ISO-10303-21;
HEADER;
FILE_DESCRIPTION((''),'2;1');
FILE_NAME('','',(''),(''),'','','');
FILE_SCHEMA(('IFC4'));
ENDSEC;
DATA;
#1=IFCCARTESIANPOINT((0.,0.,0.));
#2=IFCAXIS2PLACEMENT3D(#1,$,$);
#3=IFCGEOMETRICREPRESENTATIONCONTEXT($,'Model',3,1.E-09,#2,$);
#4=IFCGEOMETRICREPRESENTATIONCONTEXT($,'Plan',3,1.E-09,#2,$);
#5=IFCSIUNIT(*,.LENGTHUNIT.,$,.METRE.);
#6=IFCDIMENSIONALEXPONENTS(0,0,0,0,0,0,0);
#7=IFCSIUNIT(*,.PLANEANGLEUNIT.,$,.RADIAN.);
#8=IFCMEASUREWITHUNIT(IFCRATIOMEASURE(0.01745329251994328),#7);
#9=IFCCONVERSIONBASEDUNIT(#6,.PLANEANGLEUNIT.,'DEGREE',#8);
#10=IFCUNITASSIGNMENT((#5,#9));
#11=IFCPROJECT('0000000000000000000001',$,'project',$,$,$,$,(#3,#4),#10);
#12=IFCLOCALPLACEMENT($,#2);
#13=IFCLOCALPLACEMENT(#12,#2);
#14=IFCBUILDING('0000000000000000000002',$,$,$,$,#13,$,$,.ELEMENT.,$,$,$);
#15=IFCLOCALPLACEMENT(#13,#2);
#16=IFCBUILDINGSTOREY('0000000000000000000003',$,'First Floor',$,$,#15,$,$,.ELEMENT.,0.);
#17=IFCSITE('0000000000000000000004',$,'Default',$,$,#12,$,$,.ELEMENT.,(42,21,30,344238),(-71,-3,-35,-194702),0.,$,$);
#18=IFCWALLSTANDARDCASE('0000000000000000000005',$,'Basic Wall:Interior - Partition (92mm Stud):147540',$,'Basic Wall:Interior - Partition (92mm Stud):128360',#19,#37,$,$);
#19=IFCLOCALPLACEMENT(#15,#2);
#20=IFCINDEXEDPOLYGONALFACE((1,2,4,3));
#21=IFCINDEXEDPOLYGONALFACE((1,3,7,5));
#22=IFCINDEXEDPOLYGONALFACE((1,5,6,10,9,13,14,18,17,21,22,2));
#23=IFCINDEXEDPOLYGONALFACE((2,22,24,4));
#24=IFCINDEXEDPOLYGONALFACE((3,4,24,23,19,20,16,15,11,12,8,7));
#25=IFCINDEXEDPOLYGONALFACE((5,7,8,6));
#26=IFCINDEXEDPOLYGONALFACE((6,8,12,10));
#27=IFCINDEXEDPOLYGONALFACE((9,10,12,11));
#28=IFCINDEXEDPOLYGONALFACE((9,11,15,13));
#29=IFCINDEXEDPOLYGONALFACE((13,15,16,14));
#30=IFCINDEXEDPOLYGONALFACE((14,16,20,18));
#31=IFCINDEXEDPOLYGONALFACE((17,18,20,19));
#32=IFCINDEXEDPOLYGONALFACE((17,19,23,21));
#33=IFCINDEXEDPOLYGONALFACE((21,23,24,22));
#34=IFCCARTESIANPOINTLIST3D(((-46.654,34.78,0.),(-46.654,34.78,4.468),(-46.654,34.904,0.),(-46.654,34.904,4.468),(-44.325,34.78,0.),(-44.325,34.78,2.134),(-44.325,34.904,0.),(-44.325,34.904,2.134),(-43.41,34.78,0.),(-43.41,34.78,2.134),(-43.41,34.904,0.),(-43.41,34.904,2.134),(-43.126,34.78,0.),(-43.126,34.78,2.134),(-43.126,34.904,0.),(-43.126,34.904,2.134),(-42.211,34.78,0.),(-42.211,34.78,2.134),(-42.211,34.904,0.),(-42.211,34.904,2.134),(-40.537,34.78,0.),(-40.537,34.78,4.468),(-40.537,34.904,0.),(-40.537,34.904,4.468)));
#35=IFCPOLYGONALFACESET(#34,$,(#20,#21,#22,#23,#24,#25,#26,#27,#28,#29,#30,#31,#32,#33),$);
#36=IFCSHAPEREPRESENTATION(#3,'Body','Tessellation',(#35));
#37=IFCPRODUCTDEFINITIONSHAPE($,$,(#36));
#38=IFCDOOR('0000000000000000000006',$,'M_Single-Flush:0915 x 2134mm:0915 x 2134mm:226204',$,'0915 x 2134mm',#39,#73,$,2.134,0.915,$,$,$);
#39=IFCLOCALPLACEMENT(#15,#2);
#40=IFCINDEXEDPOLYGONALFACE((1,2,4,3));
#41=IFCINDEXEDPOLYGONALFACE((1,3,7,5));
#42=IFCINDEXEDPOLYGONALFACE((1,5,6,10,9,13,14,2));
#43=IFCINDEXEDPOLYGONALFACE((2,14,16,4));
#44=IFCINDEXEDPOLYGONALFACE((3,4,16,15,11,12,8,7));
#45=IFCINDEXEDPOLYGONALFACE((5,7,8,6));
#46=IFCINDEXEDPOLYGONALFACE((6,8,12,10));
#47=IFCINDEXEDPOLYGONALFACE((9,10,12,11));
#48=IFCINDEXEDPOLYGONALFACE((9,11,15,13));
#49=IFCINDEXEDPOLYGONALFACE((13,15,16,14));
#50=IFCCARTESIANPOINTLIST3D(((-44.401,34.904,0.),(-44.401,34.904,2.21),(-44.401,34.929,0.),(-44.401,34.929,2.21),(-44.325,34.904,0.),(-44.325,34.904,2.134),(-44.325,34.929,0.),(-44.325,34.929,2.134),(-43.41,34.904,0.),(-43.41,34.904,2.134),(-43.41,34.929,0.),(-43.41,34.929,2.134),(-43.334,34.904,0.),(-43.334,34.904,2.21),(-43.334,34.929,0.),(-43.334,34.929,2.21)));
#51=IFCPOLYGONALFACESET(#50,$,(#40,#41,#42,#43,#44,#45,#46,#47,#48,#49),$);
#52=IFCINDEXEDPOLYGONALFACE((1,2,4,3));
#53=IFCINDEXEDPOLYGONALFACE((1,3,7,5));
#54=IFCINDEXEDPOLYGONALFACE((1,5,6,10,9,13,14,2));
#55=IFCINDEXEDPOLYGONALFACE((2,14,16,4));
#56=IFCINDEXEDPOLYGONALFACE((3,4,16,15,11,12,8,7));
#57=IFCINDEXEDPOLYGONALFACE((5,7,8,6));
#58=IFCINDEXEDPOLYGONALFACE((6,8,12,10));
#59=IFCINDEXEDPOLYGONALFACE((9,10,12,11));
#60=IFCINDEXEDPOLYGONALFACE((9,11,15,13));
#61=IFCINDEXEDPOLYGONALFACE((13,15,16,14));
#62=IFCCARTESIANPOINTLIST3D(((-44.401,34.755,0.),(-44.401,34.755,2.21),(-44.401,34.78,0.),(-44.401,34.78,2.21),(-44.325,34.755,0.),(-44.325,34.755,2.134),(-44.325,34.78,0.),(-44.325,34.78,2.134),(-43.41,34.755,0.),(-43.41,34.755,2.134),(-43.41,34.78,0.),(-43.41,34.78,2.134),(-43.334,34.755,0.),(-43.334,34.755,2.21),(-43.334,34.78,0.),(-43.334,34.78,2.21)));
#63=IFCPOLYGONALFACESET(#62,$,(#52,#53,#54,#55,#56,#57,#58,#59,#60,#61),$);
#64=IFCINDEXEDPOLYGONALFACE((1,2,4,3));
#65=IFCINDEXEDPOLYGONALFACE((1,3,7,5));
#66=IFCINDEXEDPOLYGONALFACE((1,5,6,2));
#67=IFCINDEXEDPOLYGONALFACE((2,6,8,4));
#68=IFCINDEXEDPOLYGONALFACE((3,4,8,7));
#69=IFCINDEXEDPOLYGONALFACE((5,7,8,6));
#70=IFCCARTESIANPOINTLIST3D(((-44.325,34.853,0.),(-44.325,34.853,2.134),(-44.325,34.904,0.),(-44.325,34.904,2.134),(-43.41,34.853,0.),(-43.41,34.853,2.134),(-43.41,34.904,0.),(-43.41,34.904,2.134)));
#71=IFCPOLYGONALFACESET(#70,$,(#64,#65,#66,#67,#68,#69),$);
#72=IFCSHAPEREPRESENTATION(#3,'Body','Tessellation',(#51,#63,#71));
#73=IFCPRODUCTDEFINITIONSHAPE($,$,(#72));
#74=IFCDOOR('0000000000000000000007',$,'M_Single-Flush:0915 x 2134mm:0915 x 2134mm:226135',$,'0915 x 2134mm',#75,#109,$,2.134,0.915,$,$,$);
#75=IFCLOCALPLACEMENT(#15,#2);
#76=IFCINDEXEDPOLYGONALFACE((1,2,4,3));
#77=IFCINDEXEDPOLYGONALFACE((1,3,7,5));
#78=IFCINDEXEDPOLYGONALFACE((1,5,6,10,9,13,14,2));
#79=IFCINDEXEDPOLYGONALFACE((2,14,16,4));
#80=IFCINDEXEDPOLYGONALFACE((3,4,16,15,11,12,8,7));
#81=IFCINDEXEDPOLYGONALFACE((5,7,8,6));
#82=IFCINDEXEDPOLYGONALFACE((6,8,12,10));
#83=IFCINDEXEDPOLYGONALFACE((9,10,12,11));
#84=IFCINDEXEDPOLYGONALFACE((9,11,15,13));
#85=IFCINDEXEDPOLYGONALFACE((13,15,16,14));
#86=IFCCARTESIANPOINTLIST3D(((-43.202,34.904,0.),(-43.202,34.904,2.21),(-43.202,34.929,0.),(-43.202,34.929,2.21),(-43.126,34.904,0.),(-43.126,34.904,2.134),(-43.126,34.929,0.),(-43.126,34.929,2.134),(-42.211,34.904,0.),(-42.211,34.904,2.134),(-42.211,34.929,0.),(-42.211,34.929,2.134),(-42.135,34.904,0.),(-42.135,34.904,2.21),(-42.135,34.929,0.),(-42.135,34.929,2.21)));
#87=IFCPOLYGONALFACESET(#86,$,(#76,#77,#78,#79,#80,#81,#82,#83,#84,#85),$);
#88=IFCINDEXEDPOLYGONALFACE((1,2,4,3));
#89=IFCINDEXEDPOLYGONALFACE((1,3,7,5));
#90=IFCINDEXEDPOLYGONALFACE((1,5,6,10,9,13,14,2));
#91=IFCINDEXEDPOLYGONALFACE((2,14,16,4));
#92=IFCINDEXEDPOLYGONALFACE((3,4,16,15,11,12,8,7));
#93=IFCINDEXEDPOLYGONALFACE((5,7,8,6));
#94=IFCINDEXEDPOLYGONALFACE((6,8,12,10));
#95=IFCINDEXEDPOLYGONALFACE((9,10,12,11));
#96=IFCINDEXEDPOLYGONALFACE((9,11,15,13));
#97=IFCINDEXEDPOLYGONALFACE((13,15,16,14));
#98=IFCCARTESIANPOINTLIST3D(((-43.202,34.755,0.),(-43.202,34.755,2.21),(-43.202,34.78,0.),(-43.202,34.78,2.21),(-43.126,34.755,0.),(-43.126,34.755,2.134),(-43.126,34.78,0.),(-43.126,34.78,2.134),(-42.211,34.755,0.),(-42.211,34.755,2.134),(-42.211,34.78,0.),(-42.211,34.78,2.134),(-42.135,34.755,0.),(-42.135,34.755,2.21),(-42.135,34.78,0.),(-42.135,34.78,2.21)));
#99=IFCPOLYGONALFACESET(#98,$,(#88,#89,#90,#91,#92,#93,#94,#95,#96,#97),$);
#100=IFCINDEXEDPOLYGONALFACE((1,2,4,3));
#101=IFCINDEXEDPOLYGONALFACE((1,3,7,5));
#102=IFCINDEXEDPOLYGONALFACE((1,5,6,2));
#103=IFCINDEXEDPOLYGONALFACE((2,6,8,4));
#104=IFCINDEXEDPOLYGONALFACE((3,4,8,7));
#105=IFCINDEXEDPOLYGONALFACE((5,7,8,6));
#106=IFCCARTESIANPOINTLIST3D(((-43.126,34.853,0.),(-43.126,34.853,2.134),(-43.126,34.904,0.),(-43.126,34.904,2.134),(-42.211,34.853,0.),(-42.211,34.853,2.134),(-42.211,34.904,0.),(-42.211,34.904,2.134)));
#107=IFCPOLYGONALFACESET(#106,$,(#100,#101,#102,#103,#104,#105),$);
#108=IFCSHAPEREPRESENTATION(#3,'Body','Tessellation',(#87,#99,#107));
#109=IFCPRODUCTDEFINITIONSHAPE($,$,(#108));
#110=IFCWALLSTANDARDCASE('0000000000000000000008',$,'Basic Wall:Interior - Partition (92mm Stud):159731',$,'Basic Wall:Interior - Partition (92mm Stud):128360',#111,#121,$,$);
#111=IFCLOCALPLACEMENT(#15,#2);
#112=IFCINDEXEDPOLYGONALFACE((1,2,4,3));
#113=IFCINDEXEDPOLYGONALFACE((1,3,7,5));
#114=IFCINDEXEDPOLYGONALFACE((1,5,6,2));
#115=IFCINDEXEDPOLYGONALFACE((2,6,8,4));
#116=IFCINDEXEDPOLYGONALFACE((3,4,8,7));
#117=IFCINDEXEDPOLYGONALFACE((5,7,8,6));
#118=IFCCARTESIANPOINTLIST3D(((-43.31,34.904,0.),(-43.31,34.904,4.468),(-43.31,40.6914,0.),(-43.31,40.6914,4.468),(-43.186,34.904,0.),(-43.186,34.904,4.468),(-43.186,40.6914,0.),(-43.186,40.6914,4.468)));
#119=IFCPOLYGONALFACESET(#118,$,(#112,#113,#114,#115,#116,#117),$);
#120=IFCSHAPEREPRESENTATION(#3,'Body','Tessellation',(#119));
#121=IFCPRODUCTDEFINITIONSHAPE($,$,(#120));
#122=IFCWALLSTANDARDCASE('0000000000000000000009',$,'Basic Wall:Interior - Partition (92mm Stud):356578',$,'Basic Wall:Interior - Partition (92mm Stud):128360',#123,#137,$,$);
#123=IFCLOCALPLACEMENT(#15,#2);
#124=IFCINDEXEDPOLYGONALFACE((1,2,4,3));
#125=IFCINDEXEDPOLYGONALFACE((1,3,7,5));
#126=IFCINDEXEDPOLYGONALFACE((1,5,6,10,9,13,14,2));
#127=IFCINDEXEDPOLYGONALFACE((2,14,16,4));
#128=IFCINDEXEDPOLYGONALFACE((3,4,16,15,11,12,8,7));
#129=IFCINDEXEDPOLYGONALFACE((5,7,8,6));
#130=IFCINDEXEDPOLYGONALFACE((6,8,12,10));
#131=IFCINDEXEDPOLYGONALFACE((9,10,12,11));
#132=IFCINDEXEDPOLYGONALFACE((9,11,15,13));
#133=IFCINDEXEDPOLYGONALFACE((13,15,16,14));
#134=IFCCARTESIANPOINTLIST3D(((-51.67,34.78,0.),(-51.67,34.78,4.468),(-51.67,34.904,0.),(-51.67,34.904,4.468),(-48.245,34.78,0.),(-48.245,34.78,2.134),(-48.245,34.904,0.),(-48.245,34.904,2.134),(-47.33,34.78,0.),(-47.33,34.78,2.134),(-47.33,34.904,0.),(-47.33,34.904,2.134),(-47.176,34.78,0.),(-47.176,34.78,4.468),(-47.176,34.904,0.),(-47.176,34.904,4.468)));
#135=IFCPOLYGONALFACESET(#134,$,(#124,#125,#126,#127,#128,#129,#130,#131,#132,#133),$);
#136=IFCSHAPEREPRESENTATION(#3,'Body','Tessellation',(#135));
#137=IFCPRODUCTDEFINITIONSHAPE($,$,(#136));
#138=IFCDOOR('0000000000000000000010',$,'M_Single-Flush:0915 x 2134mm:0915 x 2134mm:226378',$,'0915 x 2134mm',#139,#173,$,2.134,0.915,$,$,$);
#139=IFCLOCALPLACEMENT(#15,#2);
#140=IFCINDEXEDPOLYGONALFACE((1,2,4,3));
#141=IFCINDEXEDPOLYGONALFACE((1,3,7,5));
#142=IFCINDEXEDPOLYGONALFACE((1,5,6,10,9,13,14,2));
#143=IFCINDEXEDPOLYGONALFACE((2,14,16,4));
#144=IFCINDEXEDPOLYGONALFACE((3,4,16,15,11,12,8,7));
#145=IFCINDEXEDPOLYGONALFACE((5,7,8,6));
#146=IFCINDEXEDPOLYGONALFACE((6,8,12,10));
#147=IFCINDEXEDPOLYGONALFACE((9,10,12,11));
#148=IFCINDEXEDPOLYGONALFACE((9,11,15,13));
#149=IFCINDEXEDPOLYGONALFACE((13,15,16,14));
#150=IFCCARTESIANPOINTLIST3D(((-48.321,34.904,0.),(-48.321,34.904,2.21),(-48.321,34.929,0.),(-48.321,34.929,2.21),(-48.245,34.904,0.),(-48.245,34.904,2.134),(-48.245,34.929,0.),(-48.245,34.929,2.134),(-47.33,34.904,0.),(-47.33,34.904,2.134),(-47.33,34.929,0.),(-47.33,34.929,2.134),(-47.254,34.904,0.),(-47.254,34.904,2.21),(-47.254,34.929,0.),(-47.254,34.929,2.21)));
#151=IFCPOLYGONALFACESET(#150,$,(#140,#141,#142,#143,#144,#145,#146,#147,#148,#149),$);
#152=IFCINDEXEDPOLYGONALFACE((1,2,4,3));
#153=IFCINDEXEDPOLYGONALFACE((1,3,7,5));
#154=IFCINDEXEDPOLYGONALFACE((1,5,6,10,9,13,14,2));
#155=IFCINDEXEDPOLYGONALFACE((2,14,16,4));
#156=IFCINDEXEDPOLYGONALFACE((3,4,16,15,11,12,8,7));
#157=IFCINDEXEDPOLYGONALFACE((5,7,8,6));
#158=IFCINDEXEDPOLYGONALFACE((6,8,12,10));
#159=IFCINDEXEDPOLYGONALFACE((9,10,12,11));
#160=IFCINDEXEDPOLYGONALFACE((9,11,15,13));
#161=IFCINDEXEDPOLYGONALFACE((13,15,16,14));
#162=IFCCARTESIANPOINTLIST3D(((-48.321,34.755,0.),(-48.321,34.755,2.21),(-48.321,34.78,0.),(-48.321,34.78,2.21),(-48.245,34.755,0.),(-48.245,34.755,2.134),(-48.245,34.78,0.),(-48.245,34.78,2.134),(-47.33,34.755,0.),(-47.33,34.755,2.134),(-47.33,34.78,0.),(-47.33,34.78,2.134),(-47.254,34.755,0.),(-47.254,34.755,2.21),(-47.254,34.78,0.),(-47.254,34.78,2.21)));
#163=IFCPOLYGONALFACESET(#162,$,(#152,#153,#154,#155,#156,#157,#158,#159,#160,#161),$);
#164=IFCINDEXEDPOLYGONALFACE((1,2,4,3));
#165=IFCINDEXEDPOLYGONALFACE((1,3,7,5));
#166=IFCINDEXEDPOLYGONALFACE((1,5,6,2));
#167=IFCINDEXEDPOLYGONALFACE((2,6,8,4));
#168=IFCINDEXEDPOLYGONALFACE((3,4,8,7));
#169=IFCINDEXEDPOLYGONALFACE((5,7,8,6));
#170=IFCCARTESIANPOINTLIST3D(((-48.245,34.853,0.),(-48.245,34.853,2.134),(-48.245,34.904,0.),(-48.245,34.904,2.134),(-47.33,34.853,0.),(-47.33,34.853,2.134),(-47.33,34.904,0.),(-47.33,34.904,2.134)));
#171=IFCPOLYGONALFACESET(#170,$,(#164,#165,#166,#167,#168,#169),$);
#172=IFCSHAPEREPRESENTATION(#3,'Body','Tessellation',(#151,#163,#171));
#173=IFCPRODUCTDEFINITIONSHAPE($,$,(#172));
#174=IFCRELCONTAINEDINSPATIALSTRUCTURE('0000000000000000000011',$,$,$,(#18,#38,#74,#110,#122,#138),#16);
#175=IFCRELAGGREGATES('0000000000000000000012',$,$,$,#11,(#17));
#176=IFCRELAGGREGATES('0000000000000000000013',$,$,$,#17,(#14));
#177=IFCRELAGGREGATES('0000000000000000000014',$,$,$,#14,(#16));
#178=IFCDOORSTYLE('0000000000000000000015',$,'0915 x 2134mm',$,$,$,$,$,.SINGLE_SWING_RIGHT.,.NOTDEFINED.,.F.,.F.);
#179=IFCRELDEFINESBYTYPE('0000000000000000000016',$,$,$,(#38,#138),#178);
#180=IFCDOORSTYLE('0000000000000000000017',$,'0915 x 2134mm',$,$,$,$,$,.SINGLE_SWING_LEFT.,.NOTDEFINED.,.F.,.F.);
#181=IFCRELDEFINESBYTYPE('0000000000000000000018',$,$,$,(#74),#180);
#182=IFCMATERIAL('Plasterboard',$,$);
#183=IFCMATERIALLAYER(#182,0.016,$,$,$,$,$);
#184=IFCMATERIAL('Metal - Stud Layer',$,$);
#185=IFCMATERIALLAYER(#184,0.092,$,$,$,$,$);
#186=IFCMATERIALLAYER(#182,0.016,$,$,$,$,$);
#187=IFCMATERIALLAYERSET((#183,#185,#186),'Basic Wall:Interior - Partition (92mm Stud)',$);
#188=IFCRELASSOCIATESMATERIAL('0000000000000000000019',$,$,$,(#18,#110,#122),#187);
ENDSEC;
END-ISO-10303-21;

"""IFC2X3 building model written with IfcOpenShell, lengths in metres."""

from ifc_helpers import new_model, entity, si_unit, converted_unit, frame, frame_2d, origin, origin_2d_with_axis, place, context, project, spatial, polyline, rectangle, outline, extrude, source, transform, mapped, material, layer, layer_set, layer_usage, type_object, type_shapes, element, fill, save


model = new_model("IFC2X3")

# Units and contexts
model_context = context("Model", 3, precision=1e-09, world=origin())
plan_context = context("Plan", 3, precision=1e-09, world=origin())
ifc_project = project(units=[si_unit("LENGTHUNIT", "METRE"), converted_unit("PLANEANGLEUNIT", "DEGREE", entity("IfcRatioMeasure", 0.01745329251994328), si_unit("PLANEANGLEUNIT", "RADIAN"), dimensions=[0, 0, 0, 0, 0, 0, 0])], contexts=[model_context, plan_context])

# Site, building, storey
site_placement = place(None, origin())
site = spatial("IfcSite", under=ifc_project, at=site_placement, Name="Default", CompositionType="ELEMENT", RefLatitude=(42, 21, 30, 344238), RefLongitude=(-71, -3, -35, -194702), RefElevation=0.0)
building_placement = place(site_placement, origin())
building = spatial("IfcBuilding", under=site, at=building_placement, CompositionType="ELEMENT")
storey_placement = place(building_placement, origin())
storey = spatial("IfcBuildingStorey", under=building, at=storey_placement, Name="First Floor", CompositionType="ELEMENT", Elevation=0.0)

# Wall, openings, doors
ifc_material_1 = material(Name="Plasterboard")
ifc_layer_1 = layer(ifc_material_1, 0.016)
ifc_material_2 = material(Name="Metal - Stud Layer")
ifc_layer_2 = layer(ifc_material_2, 0.092)
ifc_layer_3 = layer(ifc_material_1, 0.016)
ifc_layer_set_1 = layer_set([ifc_layer_1, ifc_layer_2, ifc_layer_3], Name="Basic Wall:Interior - Partition (92mm Stud)")
ifc_layer_usage_1 = layer_usage(ifc_layer_set_1, "AXIS2", "NEGATIVE", 0.062)
wall_1_placement = place(storey_placement, frame((-40.537, 34.842, 0.0), z_axis=(0.0, 0.0, 1.0), x_axis=(-1.0, 0.0, 0.0)))
wall_1 = element("IfcWallStandardCase", 1, at=wall_1_placement, inside=storey, material=ifc_layer_usage_1, Name="Basic Wall:Interior - Partition (92mm Stud):147540", ObjectType="Basic Wall:Interior - Partition (92mm Stud):128360", context=model_context, shape_type="SweptSolid", body=[
    extrude(rectangle(XDim=6.117, YDim=0.124, at=frame_2d((3.0585, 0.0), x_axis=(-1.0, 0.0))), origin(), (0.0, 0.0, 1.0), 4.468),
])
opening_1_placement = place(wall_1_placement, frame((2.589, 0.062, 0.0)))
opening_1 = element("IfcOpeningElement", 2, at=opening_1_placement, cuts=wall_1, ObjectType="Opening", context=model_context, shape_type="SweptSolid", body=[
    extrude(rectangle(XDim=0.915, YDim=2.134, at=frame_2d((1.067, 0.4575), x_axis=(0.0, -1.0))), frame((0.0, 0.0, 0.0), z_axis=(0.0, -1.0, 0.0), x_axis=(0.0, 0.0, 1.0)), (0.0, 0.0, 1.0), 0.124),
])
opening_2_placement = place(wall_1_placement, frame((3.788, 0.062, 0.0)))
opening_2 = element("IfcOpeningElement", 3, at=opening_2_placement, cuts=wall_1, ObjectType="Opening", context=model_context, shape_type="SweptSolid", body=[
    extrude(rectangle(XDim=0.915, YDim=2.134, at=frame_2d((1.067, 0.4575), x_axis=(0.0, 1.0))), frame((0.0, 0.0, 0.0), z_axis=(0.0, -1.0, 0.0), x_axis=(0.0, 0.0, 1.0)), (0.0, 0.0, 1.0), 0.124),
])
door_style_1 = type_object("IfcDoorStyle", Name="0915 x 2134mm", ConstructionType="NOTDEFINED", OperationType="SINGLE_SWING_RIGHT", ParameterTakesPrecedence=False, Sizeable=False)
shared_shape_1 = source(origin(), model_context, "Body", "SweptSolid", [
    extrude(outline(polyline([(-0.5335, -1.124), (0.5335, -1.124), (0.5335, 1.086), (0.4575, 1.086), (0.4575, -1.048), (-0.4575, -1.048), (-0.4575, 1.086), (-0.5335, 1.086), (-0.5335, -1.124)])), frame((0.4575, 0.124, 1.086), z_axis=(0.0, 1.0, 0.0), x_axis=(1.0, 0.0, 0.0)), (0.0, 0.0, 1.0), 0.025),
    extrude(outline(polyline([(-1.124, -0.5335), (1.086, -0.5335), (1.086, -0.4575), (-1.048, -0.4575), (-1.048, 0.4575), (1.086, 0.4575), (1.086, 0.5335), (-1.124, 0.5335), (-1.124, -0.5335)])), frame((0.4575, -0.025, 1.086), z_axis=(0.0, 1.0, 0.0), x_axis=(0.0, 0.0, -1.0)), (0.0, 0.0, 1.0), 0.025),
    extrude(rectangle(XDim=0.051, YDim=0.915, at=origin_2d_with_axis()), frame((0.4575, 0.0985, 0.0), z_axis=(0.0, 0.0, 1.0), x_axis=(0.0, 1.0, 0.0)), (0.0, 0.0, 1.0), 2.134),
])
type_shapes(door_style_1, [shared_shape_1])
door_1_placement = place(opening_2_placement, frame((0.0, 0.0, 0.0), z_axis=(0.0, 0.0, 1.0), x_axis=(-1.0, 0.0, 0.0)))
door_1 = element("IfcDoor", 4, at=door_1_placement, inside=storey, type_object=door_style_1, Name="M_Single-Flush:0915 x 2134mm:0915 x 2134mm:226204", ObjectType="0915 x 2134mm", OverallHeight=2.134, OverallWidth=0.915, context=model_context, shape_type="MappedRepresentation", body=[
    mapped(shared_shape_1, transform((0.0, 0.0, 0.0), scale=1.0)),
])
fill(opening_2, door_1)
door_style_2 = type_object("IfcDoorStyle", Name="0915 x 2134mm", ConstructionType="NOTDEFINED", OperationType="SINGLE_SWING_LEFT", ParameterTakesPrecedence=False, Sizeable=False)
shared_shape_2 = source(origin(), model_context, "Body", "SweptSolid", [
    extrude(outline(polyline([(-0.5335, -1.124), (0.5335, -1.124), (0.5335, 1.086), (0.4575, 1.086), (0.4575, -1.048), (-0.4575, -1.048), (-0.4575, 1.086), (-0.5335, 1.086), (-0.5335, -1.124)])), frame((0.4575, 0.149, 1.086), z_axis=(0.0, -1.0, 0.0), x_axis=(-1.0, 0.0, 0.0)), (0.0, 0.0, 1.0), 0.025),
    extrude(outline(polyline([(-1.124, -0.5335), (1.086, -0.5335), (1.086, -0.4575), (-1.048, -0.4575), (-1.048, 0.4575), (1.086, 0.4575), (1.086, 0.5335), (-1.124, 0.5335), (-1.124, -0.5335)])), frame((0.4575, 0.0, 1.086), z_axis=(0.0, -1.0, 0.0), x_axis=(0.0, 0.0, -1.0)), (0.0, 0.0, 1.0), 0.025),
    extrude(rectangle(XDim=0.915, YDim=0.051, at=origin_2d_with_axis()), frame((0.4575, 0.0985, 0.0)), (0.0, 0.0, 1.0), 2.134),
])
type_shapes(door_style_2, [shared_shape_2])
door_2_placement = place(opening_1_placement, frame((0.0, 0.0, 0.0), z_axis=(0.0, 0.0, 1.0), x_axis=(-1.0, 0.0, 0.0)))
door_2 = element("IfcDoor", 5, at=door_2_placement, inside=storey, type_object=door_style_2, Name="M_Single-Flush:0915 x 2134mm:0915 x 2134mm:226135", ObjectType="0915 x 2134mm", OverallHeight=2.134, OverallWidth=0.915, context=model_context, shape_type="MappedRepresentation", body=[
    mapped(shared_shape_2, transform((0.0, 0.0, 0.0), scale=1.0)),
])
fill(opening_1, door_2)

# Wall
wall_2_placement = place(storey_placement, frame((-43.248, 34.904, 0.0), z_axis=(0.0, 0.0, 1.0), x_axis=(0.0, 1.0, 0.0)))
element("IfcWallStandardCase", 6, at=wall_2_placement, inside=storey, material=ifc_layer_usage_1, Name="Basic Wall:Interior - Partition (92mm Stud):159731", ObjectType="Basic Wall:Interior - Partition (92mm Stud):128360", context=model_context, shape_type="SweptSolid", body=[
    extrude(rectangle(XDim=5.7874, YDim=0.124, at=frame_2d((2.8937, 0.0), x_axis=(-1.0, 0.0))), origin(), (0.0, 0.0, 1.0), 4.468),
])

# Wall, opening, door
wall_3_placement = place(storey_placement, frame((-47.176, 34.842, 0.0), z_axis=(0.0, 0.0, 1.0), x_axis=(-1.0, 0.0, 0.0)))
wall_3 = element("IfcWallStandardCase", 7, at=wall_3_placement, inside=storey, material=ifc_layer_usage_1, Name="Basic Wall:Interior - Partition (92mm Stud):356578", ObjectType="Basic Wall:Interior - Partition (92mm Stud):128360", context=model_context, shape_type="SweptSolid", body=[
    extrude(rectangle(XDim=4.494, YDim=0.124, at=frame_2d((2.247, 0.0), x_axis=(-1.0, 0.0))), origin(), (0.0, 0.0, 1.0), 4.468),
])
opening_3_placement = place(wall_3_placement, frame((1.069, 0.062, 0.0)))
opening_3 = element("IfcOpeningElement", 8, at=opening_3_placement, cuts=wall_3, ObjectType="Opening", context=model_context, shape_type="SweptSolid", body=[
    extrude(rectangle(XDim=0.915, YDim=2.134, at=frame_2d((1.067, 0.4575), x_axis=(0.0, 1.0))), frame((0.0, 0.0, 0.0), z_axis=(0.0, -1.0, 0.0), x_axis=(0.0, 0.0, 1.0)), (0.0, 0.0, 1.0), 0.124),
])
door_3_placement = place(opening_3_placement, frame((0.0, 0.0, 0.0), z_axis=(0.0, 0.0, 1.0), x_axis=(-1.0, 0.0, 0.0)))
door_3 = element("IfcDoor", 9, at=door_3_placement, inside=storey, type_object=door_style_1, Name="M_Single-Flush:0915 x 2134mm:0915 x 2134mm:226378", ObjectType="0915 x 2134mm", OverallHeight=2.134, OverallWidth=0.915, context=model_context, shape_type="MappedRepresentation", body=[
    mapped(shared_shape_1, transform((0.0, 0.0, 0.0), scale=1.0)),
])
fill(opening_3, door_3)

save(model, "model.ifc")
